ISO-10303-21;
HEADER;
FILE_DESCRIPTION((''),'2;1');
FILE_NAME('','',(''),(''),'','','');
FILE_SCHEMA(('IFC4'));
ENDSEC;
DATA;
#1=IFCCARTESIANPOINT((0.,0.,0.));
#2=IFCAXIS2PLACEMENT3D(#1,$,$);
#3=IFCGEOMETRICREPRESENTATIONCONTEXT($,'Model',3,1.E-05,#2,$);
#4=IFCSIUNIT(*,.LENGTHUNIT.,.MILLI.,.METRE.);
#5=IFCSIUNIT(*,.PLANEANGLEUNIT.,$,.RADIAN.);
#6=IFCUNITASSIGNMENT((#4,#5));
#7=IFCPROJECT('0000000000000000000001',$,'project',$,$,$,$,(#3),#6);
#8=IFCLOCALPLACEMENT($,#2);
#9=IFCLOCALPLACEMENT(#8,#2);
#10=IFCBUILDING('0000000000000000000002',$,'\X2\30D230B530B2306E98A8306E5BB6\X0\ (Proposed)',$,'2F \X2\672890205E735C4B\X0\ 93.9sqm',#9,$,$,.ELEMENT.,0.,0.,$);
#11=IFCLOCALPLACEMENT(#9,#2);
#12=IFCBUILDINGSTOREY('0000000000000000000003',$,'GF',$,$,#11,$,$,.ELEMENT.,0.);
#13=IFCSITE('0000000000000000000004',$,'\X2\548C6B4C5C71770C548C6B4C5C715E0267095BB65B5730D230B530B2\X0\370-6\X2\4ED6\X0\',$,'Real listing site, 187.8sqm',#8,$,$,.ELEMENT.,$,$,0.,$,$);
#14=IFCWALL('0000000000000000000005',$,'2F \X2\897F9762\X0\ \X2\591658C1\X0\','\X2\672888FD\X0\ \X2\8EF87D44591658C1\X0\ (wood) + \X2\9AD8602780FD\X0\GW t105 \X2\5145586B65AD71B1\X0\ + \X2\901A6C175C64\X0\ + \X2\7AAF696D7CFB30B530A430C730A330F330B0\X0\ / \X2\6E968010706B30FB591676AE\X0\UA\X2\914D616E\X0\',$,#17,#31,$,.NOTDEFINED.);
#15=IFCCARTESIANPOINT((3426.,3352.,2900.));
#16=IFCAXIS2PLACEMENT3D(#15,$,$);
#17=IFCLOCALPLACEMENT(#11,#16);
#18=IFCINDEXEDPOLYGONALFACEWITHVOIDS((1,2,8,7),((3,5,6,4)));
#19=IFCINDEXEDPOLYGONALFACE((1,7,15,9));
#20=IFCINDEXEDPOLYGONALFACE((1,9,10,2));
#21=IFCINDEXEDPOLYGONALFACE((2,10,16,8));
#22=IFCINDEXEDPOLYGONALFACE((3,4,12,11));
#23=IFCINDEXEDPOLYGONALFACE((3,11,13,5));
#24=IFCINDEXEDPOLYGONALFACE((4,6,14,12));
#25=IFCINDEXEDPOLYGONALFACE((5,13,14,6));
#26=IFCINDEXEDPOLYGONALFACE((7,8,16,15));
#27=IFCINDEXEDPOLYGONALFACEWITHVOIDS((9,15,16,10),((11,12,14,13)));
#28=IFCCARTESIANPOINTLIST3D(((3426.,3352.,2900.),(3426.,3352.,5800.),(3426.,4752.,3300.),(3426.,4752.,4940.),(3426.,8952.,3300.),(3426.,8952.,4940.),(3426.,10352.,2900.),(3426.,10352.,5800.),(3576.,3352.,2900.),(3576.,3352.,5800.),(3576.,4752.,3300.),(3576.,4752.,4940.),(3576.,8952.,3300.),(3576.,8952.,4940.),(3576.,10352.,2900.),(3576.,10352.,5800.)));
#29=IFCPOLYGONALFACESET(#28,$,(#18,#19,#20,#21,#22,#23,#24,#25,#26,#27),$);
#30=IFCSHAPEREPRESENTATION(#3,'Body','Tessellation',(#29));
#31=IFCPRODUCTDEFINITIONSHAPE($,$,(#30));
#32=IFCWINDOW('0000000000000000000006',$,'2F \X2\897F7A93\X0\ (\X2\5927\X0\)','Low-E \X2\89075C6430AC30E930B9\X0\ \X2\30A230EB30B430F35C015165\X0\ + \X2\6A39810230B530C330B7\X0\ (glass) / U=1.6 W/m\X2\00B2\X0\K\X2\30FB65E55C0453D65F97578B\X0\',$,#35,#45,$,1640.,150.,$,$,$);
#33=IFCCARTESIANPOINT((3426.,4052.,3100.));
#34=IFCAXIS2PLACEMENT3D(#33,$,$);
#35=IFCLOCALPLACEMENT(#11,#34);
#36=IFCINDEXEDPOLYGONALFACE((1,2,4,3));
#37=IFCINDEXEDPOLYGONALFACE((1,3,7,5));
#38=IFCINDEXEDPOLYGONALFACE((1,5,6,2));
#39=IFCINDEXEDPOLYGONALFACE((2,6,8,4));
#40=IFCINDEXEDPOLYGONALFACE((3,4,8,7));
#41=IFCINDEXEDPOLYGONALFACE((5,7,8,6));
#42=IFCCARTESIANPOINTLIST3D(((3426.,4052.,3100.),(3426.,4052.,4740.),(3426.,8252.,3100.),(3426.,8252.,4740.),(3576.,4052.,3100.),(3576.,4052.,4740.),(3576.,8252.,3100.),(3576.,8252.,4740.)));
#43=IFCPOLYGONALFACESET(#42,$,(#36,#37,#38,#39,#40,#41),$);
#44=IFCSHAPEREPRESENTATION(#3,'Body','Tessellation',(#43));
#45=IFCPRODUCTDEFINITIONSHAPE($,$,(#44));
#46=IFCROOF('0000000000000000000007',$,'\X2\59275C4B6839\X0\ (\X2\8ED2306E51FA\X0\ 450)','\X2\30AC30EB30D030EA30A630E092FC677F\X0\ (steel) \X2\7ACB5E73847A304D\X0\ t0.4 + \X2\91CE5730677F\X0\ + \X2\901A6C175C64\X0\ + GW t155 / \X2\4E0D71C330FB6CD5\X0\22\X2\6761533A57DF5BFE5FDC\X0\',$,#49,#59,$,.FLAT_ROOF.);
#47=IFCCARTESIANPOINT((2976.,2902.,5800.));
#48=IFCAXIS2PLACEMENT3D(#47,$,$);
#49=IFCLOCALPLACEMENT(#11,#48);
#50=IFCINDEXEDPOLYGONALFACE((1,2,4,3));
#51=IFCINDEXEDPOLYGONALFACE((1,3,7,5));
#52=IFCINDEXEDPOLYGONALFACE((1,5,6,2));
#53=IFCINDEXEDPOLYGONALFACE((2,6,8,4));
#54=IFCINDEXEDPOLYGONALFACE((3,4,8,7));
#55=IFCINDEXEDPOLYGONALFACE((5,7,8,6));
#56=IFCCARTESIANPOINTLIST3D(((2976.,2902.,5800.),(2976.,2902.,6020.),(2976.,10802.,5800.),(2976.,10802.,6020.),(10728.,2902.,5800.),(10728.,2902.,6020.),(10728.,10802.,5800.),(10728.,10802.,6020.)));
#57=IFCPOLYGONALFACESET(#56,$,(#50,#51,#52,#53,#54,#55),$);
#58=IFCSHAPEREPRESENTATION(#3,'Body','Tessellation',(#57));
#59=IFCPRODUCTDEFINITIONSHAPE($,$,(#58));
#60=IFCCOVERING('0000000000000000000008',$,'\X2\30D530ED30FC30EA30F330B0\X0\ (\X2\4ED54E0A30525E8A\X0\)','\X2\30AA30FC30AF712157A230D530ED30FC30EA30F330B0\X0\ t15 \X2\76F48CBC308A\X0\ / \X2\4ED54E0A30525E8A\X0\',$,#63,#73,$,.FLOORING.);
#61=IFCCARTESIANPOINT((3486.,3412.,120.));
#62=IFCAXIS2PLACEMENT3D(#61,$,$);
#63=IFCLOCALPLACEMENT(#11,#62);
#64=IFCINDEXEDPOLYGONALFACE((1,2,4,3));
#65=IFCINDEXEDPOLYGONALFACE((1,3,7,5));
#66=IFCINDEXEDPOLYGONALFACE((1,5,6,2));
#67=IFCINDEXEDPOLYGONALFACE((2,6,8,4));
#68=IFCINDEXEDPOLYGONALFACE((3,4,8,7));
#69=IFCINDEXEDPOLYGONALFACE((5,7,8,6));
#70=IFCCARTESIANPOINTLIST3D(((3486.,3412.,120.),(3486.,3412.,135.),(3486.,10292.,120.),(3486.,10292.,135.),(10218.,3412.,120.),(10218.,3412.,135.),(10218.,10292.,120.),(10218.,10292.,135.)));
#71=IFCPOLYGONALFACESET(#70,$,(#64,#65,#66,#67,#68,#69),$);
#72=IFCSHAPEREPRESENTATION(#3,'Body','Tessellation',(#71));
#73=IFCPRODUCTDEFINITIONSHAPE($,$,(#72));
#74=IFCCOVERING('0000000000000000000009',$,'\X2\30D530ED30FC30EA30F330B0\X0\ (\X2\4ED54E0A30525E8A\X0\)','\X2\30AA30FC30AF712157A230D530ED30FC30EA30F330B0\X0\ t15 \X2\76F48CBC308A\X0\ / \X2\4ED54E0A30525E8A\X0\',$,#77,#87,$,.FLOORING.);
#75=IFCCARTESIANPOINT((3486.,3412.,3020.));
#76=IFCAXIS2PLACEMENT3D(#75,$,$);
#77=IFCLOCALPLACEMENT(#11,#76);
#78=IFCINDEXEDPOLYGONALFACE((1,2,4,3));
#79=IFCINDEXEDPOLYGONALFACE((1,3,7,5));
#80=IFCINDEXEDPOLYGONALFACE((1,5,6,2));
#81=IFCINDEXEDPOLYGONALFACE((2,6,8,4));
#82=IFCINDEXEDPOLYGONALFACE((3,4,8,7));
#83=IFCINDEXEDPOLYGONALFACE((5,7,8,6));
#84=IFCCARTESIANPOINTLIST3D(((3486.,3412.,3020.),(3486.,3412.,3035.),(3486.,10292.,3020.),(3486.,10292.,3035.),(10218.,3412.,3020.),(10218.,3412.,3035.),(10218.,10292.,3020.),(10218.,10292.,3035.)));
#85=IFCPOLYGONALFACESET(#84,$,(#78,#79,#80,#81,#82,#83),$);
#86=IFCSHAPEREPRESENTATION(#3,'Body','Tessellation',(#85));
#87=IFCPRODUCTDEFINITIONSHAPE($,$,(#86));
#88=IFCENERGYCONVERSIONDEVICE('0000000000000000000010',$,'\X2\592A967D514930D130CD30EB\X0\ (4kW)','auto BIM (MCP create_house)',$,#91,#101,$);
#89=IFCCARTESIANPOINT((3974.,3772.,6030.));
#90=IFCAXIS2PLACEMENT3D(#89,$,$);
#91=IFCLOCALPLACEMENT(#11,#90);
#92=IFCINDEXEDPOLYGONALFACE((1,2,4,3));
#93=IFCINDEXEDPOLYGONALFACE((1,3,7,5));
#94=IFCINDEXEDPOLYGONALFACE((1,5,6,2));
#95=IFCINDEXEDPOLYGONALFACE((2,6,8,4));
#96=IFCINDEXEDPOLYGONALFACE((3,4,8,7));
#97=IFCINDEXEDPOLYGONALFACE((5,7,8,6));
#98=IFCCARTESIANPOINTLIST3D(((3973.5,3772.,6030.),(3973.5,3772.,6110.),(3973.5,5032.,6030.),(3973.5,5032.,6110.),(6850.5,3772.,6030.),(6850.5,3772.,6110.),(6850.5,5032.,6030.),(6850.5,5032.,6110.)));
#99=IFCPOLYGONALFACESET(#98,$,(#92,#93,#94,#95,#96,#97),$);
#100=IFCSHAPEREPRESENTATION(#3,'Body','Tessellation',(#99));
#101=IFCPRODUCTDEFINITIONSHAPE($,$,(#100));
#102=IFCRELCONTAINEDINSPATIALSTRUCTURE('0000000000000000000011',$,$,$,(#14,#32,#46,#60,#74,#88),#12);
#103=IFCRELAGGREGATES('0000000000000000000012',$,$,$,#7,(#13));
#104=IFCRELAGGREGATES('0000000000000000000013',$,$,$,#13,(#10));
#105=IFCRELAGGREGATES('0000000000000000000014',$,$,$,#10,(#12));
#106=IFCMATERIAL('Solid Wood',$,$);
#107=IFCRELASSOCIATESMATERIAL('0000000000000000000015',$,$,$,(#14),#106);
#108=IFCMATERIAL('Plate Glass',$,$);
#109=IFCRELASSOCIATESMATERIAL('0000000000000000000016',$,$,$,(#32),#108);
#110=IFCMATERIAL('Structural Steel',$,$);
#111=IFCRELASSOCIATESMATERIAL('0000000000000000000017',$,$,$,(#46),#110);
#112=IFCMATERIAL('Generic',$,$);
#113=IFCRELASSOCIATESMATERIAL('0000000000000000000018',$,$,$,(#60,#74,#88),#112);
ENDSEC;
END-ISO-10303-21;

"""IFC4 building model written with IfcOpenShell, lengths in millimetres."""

from ifc_helpers import new_model, si_unit, frame, frame_2d, origin, place, context, project, spatial, rectangle, extrude, material, element, fill, save


model = new_model("IFC4")

# Units and contexts
model_context = context("Model", 3, precision=1e-05, world=origin())
ifc_project = project(units=[si_unit("LENGTHUNIT", "METRE", prefix="MILLI"), si_unit("PLANEANGLEUNIT", "RADIAN")], contexts=[model_context])

# Site, building, storey
site_placement = place(None, origin())
site = spatial("IfcSite", under=ifc_project, at=site_placement, Name="和歌山県和歌山市有家字ヒサゲ370-6他", ObjectType="Real listing site, 187.8sqm", CompositionType="ELEMENT", RefElevation=0.0)
building_placement = place(site_placement, origin())
building = spatial("IfcBuilding", under=site, at=building_placement, Name="ヒサゲの風の家 (Proposed)", ObjectType="2F 木造平屋 93.9sqm", CompositionType="ELEMENT", ElevationOfRefHeight=0.0, ElevationOfTerrain=0.0)
storey_placement = place(building_placement, origin())
storey = spatial("IfcBuildingStorey", under=building, at=storey_placement, Name="GF", CompositionType="ELEMENT", Elevation=0.0)

# Shared definitions
ifc_material_1 = material(Name="Solid Wood")

# Shared definitions
ifc_material_2 = material(Name="Plate Glass")

# Wall, opening, window
wall_1_placement = place(storey_placement, frame((3426.0, 3352.0, 2900.0)))
wall_1 = element("IfcWall", 1, at=wall_1_placement, inside=storey, material=ifc_material_1, Name="2F 西面 外壁", Description="木製 軸組外壁 (wood) + 高性能GW t105 充填断熱 + 通気層 + 窯業系サイディング / 準耐火・外皮UA配慮", PredefinedType="NOTDEFINED", context=model_context, shape_type="SweptSolid", body=[
    extrude(rectangle(XDim=150.0, YDim=7000.0, at=frame_2d((75.0, 3500.0))), frame((3426.0, 3352.0, 2900.0)), (0.0, 0.0, 1.0), 2900.0),
])
opening_1_placement = place(storey_placement, frame((3426.0, 4052.0, 3100.0)))
opening_1 = element("IfcOpeningElement", 2, at=opening_1_placement, cuts=wall_1, PredefinedType="NOTDEFINED", context=model_context, shape_type="SweptSolid", body=[
    extrude(rectangle(XDim=150.0, YDim=4200.0, at=frame_2d((75.0, 2100.0))), frame((3426.0, 4052.0, 3100.0)), (0.0, 0.0, 1.0), 1640.0),
])
window_1_placement = place(storey_placement, frame((3426.0, 4052.0, 3100.0)))
window_1 = element("IfcWindow", 3, at=window_1_placement, inside=storey, material=ifc_material_2, Name="2F 西窓 (大)", Description="Low-E 複層ガラス アルゴン封入 + 樹脂サッシ (glass) / U=1.6 W/m²K・日射取得型", OverallHeight=1640.0, OverallWidth=150.0, context=model_context, shape_type="SweptSolid", body=[
    extrude(rectangle(XDim=150.0, YDim=4200.0, at=frame_2d((75.0, 2100.0))), frame((3426.0, 4052.0, 3100.0)), (0.0, 0.0, 1.0), 1640.0),
])
fill(opening_1, window_1)

# Roof
ifc_material_3 = material(Name="Structural Steel")
roof_placement = place(storey_placement, frame((2976.0, 2902.0, 5800.0)))
element("IfcRoof", 4, at=roof_placement, inside=storey, material=ifc_material_3, Name="大屋根 (軒の出 450)", Description="ガルバリウム鋼板 (steel) 立平葺き t0.4 + 野地板 + 通気層 + GW t155 / 不燃・法22条区域対応", PredefinedType="FLAT_ROOF", context=model_context, shape_type="SweptSolid", body=[
    extrude(rectangle(XDim=7752.0, YDim=7900.0, at=frame_2d((3876.0, 3950.0))), frame((2976.0, 2902.0, 5800.0)), (0.0, 0.0, 1.0), 220.0),
])

# Coverings
ifc_material_4 = material(Name="Generic")
covering_1_placement = place(storey_placement, frame((3486.0, 3412.0, 120.0)))
element("IfcCovering", 5, at=covering_1_placement, inside=storey, material=ifc_material_4, Name="フローリング (仕上げ床)", Description="オーク無垢フローリング t15 直貼り / 仕上げ床", PredefinedType="FLOORING", context=model_context, shape_type="SweptSolid", body=[
    extrude(rectangle(XDim=6732.0, YDim=6880.0, at=frame_2d((3366.0, 3440.0))), frame((3486.0, 3412.0, 120.0)), (0.0, 0.0, 1.0), 15.0),
])
covering_2_placement = place(storey_placement, frame((3486.0, 3412.0, 3020.0)))
element("IfcCovering", 6, at=covering_2_placement, inside=storey, material=ifc_material_4, Name="フローリング (仕上げ床)", Description="オーク無垢フローリング t15 直貼り / 仕上げ床", PredefinedType="FLOORING", context=model_context, shape_type="SweptSolid", body=[
    extrude(rectangle(XDim=6732.0, YDim=6880.0, at=frame_2d((3366.0, 3440.0))), frame((3486.0, 3412.0, 3020.0)), (0.0, 0.0, 1.0), 15.0),
])

# Energy conversion device
energy_conversion_device_placement = place(storey_placement, frame((3974.0, 3772.0, 6030.0)))
element("IfcEnergyConversionDevice", 7, at=energy_conversion_device_placement, inside=storey, material=ifc_material_4, Name="太陽光パネル (4kW)", Description="auto BIM (MCP create_house)", context=model_context, shape_type="SweptSolid", body=[
    extrude(rectangle(XDim=2877.0, YDim=1260.0, at=frame_2d((1438.0, 630.0))), frame((3974.0, 3772.0, 6030.0)), (0.0, 0.0, 1.0), 80.0),
])

save(model, "model.ifc")
